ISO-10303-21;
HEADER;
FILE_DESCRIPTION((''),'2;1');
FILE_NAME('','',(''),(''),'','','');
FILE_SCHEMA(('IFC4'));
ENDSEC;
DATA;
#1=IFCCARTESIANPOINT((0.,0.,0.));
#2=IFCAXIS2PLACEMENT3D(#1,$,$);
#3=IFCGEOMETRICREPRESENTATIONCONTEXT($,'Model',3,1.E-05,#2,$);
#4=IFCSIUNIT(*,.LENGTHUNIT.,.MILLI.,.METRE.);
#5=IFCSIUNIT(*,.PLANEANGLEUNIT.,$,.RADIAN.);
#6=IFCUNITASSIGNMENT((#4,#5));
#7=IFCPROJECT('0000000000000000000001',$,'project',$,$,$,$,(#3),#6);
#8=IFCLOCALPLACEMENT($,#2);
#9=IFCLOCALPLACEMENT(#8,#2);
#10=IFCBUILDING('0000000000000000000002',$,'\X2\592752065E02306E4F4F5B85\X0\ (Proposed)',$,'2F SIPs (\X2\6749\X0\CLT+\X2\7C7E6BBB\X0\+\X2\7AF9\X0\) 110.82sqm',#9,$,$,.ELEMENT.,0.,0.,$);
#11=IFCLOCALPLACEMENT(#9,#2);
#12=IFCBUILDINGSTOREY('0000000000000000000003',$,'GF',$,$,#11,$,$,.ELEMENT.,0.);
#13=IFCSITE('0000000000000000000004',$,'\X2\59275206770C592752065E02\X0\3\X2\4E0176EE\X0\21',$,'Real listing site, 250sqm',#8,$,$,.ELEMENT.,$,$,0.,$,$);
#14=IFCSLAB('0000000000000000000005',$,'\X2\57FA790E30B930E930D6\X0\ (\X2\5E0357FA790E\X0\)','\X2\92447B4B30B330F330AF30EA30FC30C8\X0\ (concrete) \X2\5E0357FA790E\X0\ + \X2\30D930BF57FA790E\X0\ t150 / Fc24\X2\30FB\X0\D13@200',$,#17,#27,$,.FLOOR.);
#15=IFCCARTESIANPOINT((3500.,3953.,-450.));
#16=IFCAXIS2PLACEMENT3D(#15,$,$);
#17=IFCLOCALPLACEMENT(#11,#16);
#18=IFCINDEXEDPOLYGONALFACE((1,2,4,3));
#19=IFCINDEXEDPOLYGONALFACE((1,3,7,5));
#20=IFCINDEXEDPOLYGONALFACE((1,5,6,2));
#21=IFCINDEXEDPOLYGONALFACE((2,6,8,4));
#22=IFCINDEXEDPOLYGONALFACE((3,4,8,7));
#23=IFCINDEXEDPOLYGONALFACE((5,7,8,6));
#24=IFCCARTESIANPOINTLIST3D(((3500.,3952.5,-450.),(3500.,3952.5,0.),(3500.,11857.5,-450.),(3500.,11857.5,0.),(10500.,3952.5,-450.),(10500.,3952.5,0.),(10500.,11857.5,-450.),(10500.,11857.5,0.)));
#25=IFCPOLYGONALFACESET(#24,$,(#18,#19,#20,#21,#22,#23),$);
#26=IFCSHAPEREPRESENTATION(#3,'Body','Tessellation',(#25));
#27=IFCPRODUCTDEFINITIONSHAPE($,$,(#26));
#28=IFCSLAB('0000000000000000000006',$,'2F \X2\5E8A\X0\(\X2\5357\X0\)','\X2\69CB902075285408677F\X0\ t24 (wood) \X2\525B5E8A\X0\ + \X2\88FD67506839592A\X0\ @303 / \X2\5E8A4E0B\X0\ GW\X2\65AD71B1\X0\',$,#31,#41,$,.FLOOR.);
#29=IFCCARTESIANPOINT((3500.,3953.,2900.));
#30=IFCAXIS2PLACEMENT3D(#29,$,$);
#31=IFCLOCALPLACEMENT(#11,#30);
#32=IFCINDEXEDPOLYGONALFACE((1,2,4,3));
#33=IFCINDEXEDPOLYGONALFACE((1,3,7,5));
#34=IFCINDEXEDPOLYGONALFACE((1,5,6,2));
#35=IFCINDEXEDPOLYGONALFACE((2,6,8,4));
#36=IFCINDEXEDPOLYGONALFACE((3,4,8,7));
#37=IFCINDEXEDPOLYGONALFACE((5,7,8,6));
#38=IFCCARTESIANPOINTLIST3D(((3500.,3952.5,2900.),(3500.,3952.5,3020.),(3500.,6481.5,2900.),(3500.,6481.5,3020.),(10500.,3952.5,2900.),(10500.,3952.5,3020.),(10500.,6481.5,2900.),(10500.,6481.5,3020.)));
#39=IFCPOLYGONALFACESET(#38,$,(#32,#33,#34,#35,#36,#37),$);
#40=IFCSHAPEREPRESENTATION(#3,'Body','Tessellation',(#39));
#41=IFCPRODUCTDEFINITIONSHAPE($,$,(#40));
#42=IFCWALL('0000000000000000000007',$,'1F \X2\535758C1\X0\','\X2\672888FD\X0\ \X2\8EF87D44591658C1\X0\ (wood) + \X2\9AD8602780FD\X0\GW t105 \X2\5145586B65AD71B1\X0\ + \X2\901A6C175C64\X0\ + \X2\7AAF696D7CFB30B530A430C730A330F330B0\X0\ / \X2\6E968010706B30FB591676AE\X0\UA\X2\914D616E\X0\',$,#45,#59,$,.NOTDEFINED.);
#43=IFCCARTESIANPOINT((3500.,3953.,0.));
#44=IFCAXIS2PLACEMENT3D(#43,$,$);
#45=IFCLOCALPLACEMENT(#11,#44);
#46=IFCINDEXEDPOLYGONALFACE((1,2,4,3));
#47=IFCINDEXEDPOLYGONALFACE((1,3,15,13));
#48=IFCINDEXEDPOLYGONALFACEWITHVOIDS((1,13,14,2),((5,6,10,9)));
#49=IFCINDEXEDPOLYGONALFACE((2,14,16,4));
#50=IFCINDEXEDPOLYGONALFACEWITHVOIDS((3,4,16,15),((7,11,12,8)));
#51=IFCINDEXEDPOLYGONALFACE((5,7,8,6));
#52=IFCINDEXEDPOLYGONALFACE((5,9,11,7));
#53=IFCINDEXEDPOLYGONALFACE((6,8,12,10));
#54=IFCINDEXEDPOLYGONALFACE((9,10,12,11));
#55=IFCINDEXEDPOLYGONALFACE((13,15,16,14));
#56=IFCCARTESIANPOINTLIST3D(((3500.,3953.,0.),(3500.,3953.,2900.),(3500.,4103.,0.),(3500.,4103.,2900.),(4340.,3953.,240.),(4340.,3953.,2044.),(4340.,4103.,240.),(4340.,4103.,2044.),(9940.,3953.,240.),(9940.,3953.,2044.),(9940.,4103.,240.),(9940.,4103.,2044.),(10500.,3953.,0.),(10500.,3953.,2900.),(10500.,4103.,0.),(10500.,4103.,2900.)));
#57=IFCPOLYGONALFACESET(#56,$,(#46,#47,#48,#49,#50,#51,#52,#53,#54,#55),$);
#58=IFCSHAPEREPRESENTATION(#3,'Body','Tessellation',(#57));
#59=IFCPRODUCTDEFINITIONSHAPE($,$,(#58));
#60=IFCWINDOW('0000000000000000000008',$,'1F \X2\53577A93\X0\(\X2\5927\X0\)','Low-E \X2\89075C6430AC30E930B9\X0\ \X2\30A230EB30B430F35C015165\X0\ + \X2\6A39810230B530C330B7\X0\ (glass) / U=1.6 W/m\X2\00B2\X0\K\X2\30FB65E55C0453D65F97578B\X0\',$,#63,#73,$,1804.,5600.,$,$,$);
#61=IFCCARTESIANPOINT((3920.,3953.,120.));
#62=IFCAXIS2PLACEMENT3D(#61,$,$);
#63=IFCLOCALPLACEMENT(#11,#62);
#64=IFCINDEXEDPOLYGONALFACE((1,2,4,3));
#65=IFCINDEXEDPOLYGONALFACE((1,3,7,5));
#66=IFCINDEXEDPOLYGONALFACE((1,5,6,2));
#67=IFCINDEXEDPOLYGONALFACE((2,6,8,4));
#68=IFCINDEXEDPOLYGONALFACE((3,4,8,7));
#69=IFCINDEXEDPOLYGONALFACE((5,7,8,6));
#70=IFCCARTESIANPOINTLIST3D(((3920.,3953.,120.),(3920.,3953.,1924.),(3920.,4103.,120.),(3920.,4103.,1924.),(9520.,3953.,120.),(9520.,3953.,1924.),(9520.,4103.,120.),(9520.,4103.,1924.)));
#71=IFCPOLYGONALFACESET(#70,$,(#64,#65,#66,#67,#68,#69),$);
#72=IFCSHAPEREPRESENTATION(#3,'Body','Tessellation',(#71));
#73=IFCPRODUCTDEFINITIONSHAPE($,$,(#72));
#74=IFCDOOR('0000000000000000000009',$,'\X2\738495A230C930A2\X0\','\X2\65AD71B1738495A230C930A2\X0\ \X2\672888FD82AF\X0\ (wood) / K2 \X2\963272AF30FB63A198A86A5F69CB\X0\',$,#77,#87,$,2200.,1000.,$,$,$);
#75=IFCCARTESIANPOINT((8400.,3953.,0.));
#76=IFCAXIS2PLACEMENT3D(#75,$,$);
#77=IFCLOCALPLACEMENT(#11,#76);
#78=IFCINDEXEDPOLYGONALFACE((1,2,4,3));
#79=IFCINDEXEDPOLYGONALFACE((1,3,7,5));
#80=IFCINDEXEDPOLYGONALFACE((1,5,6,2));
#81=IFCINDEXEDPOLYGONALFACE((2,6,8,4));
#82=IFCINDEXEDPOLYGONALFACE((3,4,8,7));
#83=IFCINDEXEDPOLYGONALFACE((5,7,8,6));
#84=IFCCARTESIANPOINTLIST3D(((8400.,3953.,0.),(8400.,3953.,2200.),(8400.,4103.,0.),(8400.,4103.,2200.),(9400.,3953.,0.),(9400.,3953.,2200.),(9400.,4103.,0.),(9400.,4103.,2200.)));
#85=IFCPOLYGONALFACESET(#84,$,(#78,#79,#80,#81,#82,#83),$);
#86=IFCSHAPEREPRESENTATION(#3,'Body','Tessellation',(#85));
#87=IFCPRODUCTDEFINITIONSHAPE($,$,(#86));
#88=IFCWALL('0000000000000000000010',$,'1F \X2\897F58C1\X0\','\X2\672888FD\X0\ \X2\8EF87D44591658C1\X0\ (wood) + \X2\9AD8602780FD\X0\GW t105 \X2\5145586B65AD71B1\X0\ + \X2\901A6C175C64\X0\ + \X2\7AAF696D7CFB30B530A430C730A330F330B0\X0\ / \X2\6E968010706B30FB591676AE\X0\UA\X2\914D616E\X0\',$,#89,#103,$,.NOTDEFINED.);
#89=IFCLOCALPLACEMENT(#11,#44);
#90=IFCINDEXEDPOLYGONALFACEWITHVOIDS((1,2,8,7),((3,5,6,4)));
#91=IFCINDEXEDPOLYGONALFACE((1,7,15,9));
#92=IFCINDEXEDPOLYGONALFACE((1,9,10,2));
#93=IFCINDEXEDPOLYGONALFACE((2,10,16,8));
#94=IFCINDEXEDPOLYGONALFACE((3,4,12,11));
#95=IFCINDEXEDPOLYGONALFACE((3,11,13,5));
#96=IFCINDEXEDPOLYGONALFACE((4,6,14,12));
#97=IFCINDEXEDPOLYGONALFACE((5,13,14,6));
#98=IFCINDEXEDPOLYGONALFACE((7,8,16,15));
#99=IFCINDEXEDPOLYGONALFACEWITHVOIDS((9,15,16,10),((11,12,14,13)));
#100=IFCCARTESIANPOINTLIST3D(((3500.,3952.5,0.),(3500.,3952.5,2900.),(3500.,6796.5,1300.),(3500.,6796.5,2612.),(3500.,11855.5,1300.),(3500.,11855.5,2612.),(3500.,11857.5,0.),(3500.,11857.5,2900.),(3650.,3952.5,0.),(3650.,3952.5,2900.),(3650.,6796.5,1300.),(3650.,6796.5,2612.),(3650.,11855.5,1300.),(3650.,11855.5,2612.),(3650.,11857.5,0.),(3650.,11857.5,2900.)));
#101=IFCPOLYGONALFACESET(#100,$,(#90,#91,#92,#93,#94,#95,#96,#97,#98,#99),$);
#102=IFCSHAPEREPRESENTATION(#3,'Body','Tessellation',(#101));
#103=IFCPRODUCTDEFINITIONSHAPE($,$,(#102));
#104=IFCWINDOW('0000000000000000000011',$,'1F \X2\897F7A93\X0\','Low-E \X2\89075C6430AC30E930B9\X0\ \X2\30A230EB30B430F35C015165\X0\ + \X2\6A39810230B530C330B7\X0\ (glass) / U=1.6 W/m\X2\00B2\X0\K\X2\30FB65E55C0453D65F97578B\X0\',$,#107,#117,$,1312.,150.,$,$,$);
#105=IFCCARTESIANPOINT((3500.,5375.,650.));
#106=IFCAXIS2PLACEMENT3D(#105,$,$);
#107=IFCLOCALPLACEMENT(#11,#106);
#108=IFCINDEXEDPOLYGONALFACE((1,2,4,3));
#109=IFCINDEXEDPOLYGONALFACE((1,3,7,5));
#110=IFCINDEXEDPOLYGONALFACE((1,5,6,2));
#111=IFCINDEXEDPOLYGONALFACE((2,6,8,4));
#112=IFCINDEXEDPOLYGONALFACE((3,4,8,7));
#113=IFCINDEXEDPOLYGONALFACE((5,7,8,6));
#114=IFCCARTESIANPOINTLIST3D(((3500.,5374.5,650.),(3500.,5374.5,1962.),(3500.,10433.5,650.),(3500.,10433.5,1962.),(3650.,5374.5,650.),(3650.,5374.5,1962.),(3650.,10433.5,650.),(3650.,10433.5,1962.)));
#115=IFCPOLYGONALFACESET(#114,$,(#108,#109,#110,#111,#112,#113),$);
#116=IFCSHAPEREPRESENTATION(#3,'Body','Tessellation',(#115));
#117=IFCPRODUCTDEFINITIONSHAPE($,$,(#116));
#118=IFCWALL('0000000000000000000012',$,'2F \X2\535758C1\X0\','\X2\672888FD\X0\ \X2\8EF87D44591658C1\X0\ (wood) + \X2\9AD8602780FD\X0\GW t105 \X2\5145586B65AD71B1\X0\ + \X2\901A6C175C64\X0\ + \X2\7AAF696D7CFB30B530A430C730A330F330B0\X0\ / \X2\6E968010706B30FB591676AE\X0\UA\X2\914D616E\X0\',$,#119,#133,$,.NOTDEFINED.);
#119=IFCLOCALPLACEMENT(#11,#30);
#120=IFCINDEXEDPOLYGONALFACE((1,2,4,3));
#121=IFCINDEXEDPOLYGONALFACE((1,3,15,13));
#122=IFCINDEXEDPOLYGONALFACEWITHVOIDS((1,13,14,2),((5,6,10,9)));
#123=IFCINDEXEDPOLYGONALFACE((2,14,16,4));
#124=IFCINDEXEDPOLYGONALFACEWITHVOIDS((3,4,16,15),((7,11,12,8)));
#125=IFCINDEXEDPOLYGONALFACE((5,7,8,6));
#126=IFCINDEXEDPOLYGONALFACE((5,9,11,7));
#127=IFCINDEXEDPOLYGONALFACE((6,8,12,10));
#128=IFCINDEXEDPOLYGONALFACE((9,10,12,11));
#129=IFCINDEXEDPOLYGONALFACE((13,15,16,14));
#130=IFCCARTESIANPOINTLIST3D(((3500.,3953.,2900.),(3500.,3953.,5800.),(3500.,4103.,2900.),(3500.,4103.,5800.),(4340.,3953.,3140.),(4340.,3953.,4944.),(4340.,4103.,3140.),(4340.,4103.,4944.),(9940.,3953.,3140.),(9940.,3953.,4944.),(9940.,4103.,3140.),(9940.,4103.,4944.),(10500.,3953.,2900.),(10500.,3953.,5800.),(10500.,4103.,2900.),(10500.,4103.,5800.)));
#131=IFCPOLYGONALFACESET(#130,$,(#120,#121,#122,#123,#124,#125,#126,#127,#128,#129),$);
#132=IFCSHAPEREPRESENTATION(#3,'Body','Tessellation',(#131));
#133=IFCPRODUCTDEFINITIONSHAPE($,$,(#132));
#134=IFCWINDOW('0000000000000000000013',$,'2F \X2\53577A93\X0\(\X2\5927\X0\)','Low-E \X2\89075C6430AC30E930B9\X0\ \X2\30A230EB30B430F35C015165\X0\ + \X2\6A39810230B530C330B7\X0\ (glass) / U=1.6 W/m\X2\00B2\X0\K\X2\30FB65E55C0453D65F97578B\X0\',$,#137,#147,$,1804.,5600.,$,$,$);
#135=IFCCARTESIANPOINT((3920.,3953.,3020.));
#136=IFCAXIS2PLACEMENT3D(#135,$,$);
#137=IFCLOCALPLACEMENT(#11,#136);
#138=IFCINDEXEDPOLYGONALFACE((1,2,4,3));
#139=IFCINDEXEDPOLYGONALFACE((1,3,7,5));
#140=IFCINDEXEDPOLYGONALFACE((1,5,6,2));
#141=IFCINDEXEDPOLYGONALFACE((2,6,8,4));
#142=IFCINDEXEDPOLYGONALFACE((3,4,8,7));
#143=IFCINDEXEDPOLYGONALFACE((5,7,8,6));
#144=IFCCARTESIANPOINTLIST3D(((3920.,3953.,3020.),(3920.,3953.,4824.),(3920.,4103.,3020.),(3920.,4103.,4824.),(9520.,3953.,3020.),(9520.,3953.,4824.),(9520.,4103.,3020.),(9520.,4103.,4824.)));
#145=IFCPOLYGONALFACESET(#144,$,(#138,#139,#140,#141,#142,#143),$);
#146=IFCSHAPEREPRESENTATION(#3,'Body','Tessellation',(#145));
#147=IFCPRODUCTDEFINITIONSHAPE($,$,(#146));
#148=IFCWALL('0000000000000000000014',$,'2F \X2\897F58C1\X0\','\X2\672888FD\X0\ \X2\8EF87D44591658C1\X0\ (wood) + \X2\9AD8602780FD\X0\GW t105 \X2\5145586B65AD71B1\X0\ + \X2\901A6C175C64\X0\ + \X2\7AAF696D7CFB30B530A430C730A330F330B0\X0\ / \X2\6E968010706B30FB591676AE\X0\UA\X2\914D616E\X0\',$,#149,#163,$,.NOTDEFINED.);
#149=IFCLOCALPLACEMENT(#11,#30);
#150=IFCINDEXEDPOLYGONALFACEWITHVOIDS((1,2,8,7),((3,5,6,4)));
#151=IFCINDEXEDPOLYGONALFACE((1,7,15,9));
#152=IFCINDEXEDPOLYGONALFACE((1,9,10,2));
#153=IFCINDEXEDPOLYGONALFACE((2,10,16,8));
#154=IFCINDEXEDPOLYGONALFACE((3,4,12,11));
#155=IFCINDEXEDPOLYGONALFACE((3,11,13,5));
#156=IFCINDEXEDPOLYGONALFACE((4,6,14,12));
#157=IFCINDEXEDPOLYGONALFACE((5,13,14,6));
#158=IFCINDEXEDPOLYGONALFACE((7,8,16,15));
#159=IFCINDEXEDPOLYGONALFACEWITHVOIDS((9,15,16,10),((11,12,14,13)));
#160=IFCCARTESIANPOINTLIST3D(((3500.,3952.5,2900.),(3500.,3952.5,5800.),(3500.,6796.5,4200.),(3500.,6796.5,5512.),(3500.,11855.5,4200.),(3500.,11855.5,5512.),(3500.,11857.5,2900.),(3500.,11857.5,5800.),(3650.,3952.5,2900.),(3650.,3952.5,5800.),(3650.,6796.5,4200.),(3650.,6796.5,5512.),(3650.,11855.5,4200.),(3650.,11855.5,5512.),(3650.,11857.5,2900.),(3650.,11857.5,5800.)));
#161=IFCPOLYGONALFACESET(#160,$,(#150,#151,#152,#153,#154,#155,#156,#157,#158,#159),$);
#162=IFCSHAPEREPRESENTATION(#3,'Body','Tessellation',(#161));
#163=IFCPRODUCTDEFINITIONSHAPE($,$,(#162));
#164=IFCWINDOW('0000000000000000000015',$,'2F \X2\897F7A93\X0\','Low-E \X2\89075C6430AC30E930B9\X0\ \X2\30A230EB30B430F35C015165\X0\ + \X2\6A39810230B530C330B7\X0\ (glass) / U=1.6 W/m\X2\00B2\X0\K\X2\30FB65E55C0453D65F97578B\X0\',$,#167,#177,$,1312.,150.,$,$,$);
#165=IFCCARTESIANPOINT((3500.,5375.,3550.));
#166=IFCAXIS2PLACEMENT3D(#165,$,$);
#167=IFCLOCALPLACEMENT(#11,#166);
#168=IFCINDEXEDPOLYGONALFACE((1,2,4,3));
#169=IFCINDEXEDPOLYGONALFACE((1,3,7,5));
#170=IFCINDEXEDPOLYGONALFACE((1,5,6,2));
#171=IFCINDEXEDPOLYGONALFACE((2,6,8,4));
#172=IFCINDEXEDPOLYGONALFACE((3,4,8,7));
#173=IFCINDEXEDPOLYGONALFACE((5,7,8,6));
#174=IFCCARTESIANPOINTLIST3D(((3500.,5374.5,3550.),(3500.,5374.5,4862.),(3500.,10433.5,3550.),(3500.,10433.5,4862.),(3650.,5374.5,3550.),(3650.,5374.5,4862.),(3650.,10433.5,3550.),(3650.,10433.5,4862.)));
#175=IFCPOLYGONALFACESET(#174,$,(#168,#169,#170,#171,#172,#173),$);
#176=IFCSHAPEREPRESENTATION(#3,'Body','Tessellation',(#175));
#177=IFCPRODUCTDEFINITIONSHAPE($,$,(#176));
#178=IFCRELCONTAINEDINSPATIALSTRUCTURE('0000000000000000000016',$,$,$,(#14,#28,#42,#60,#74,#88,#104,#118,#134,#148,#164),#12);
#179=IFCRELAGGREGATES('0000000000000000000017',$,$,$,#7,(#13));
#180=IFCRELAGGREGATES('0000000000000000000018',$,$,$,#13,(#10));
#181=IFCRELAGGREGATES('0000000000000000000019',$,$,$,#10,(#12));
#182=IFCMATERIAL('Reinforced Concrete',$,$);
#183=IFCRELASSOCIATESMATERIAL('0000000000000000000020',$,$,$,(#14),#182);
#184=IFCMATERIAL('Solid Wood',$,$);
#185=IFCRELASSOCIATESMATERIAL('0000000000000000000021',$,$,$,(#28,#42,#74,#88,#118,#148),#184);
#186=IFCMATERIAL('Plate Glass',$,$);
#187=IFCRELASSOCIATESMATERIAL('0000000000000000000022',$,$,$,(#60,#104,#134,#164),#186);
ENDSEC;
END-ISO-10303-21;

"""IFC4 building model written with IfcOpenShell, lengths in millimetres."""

from ifc_helpers import new_model, si_unit, frame, frame_2d, origin, place, context, project, spatial, rectangle, extrude, material, element, fill, save


model = new_model("IFC4")

# Units and contexts
model_context = context("Model", 3, precision=1e-05, world=origin())
ifc_project = project(units=[si_unit("LENGTHUNIT", "METRE", prefix="MILLI"), si_unit("PLANEANGLEUNIT", "RADIAN")], contexts=[model_context])

# Site, building, storey
site_placement = place(None, origin())
site = spatial("IfcSite", under=ifc_project, at=site_placement, Name="大分県大分市3丁目21", ObjectType="Real listing site, 250sqm", CompositionType="ELEMENT", RefElevation=0.0)
building_placement = place(site_placement, origin())
building = spatial("IfcBuilding", under=site, at=building_placement, Name="大分市の住宅 (Proposed)", ObjectType="2F SIPs (杉CLT+籾殻+竹) 110.82sqm", CompositionType="ELEMENT", ElevationOfRefHeight=0.0, ElevationOfTerrain=0.0)
storey_placement = place(building_placement, origin())
storey = spatial("IfcBuildingStorey", under=building, at=storey_placement, Name="GF", CompositionType="ELEMENT", Elevation=0.0)

# Slabs
ifc_material_1 = material(Name="Reinforced Concrete")
slab_1_placement = place(storey_placement, frame((3500.0, 3953.0, -450.0)))
element("IfcSlab", 1, at=slab_1_placement, inside=storey, material=ifc_material_1, Name="基礎スラブ (布基礎)", Description="鉄筋コンクリート (concrete) 布基礎 + ベタ基礎 t150 / Fc24・D13@200", PredefinedType="FLOOR", context=model_context, shape_type="SweptSolid", body=[
    extrude(rectangle(XDim=7000.0, YDim=7905.0, at=frame_2d((3500.0, 3952.0))), frame((3500.0, 3953.0, -450.0)), (0.0, 0.0, 1.0), 450.0),
])
ifc_material_2 = material(Name="Solid Wood")
slab_2_placement = place(storey_placement, frame((3500.0, 3953.0, 2900.0)))
element("IfcSlab", 2, at=slab_2_placement, inside=storey, material=ifc_material_2, Name="2F 床(南)", Description="構造用合板 t24 (wood) 剛床 + 製材根太 @303 / 床下 GW断熱", PredefinedType="FLOOR", context=model_context, shape_type="SweptSolid", body=[
    extrude(rectangle(XDim=7000.0, YDim=2529.0, at=frame_2d((3500.0, 1264.0))), frame((3500.0, 3953.0, 2900.0)), (0.0, 0.0, 1.0), 120.0),
])

# Wall, openings, window, door
wall_1_placement = place(storey_placement, frame((3500.0, 3953.0, 0.0)))
wall_1 = element("IfcWall", 3, at=wall_1_placement, inside=storey, material=ifc_material_2, Name="1F 南壁", Description="木製 軸組外壁 (wood) + 高性能GW t105 充填断熱 + 通気層 + 窯業系サイディング / 準耐火・外皮UA配慮", PredefinedType="NOTDEFINED", context=model_context, shape_type="SweptSolid", body=[
    extrude(rectangle(XDim=7000.0, YDim=150.0, at=frame_2d((3500.0, 75.0))), frame((3500.0, 3953.0, 0.0)), (0.0, 0.0, 1.0), 2900.0),
])
opening_1_placement = place(storey_placement, frame((3920.0, 3953.0, 120.0)))
opening_1 = element("IfcOpeningElement", 4, at=opening_1_placement, cuts=wall_1, PredefinedType="NOTDEFINED", context=model_context, shape_type="SweptSolid", body=[
    extrude(rectangle(XDim=5600.0, YDim=150.0, at=frame_2d((2800.0, 75.0))), frame((3920.0, 3953.0, 120.0)), (0.0, 0.0, 1.0), 1804.0),
])
opening_2_placement = place(storey_placement, frame((8400.0, 3953.0, 0.0)))
opening_2 = element("IfcOpeningElement", 5, at=opening_2_placement, cuts=wall_1, PredefinedType="NOTDEFINED", context=model_context, shape_type="SweptSolid", body=[
    extrude(rectangle(XDim=1000.0, YDim=150.0, at=frame_2d((500.0, 75.0))), frame((8400.0, 3953.0, 0.0)), (0.0, 0.0, 1.0), 2200.0),
])
ifc_material_3 = material(Name="Plate Glass")
window_1_placement = place(storey_placement, frame((3920.0, 3953.0, 120.0)))
window_1 = element("IfcWindow", 6, at=window_1_placement, inside=storey, material=ifc_material_3, Name="1F 南窓(大)", Description="Low-E 複層ガラス アルゴン封入 + 樹脂サッシ (glass) / U=1.6 W/m²K・日射取得型", OverallHeight=1804.0, OverallWidth=5600.0, context=model_context, shape_type="SweptSolid", body=[
    extrude(rectangle(XDim=5600.0, YDim=150.0, at=frame_2d((2800.0, 75.0))), frame((3920.0, 3953.0, 120.0)), (0.0, 0.0, 1.0), 1804.0),
])
fill(opening_1, window_1)
door_placement = place(storey_placement, frame((8400.0, 3953.0, 0.0)))
door = element("IfcDoor", 7, at=door_placement, inside=storey, material=ifc_material_2, Name="玄関ドア", Description="断熱玄関ドア 木製芯 (wood) / K2 防犯・採風機構", OverallHeight=2200.0, OverallWidth=1000.0, context=model_context, shape_type="SweptSolid", body=[
    extrude(rectangle(XDim=1000.0, YDim=150.0, at=frame_2d((500.0, 75.0))), frame((8400.0, 3953.0, 0.0)), (0.0, 0.0, 1.0), 2200.0),
])
fill(opening_2, door)

# Walls, openings, windows
wall_2_placement = place(storey_placement, frame((3500.0, 3953.0, 0.0)))
wall_2 = element("IfcWall", 8, at=wall_2_placement, inside=storey, material=ifc_material_2, Name="1F 西壁", Description="木製 軸組外壁 (wood) + 高性能GW t105 充填断熱 + 通気層 + 窯業系サイディング / 準耐火・外皮UA配慮", PredefinedType="NOTDEFINED", context=model_context, shape_type="SweptSolid", body=[
    extrude(rectangle(XDim=150.0, YDim=7905.0, at=frame_2d((75.0, 3952.0))), frame((3500.0, 3953.0, 0.0)), (0.0, 0.0, 1.0), 2900.0),
])
opening_3_placement = place(storey_placement, frame((3500.0, 5375.0, 650.0)))
opening_3 = element("IfcOpeningElement", 9, at=opening_3_placement, cuts=wall_2, PredefinedType="NOTDEFINED", context=model_context, shape_type="SweptSolid", body=[
    extrude(rectangle(XDim=150.0, YDim=5059.0, at=frame_2d((75.0, 2529.0))), frame((3500.0, 5375.0, 650.0)), (0.0, 0.0, 1.0), 1312.0),
])
window_2_placement = place(storey_placement, frame((3500.0, 5375.0, 650.0)))
window_2 = element("IfcWindow", 10, at=window_2_placement, inside=storey, material=ifc_material_3, Name="1F 西窓", Description="Low-E 複層ガラス アルゴン封入 + 樹脂サッシ (glass) / U=1.6 W/m²K・日射取得型", OverallHeight=1312.0, OverallWidth=150.0, context=model_context, shape_type="SweptSolid", body=[
    extrude(rectangle(XDim=150.0, YDim=5059.0, at=frame_2d((75.0, 2529.0))), frame((3500.0, 5375.0, 650.0)), (0.0, 0.0, 1.0), 1312.0),
])
fill(opening_3, window_2)
wall_3_placement = place(storey_placement, frame((3500.0, 3953.0, 2900.0)))
wall_3 = element("IfcWall", 11, at=wall_3_placement, inside=storey, material=ifc_material_2, Name="2F 南壁", Description="木製 軸組外壁 (wood) + 高性能GW t105 充填断熱 + 通気層 + 窯業系サイディング / 準耐火・外皮UA配慮", PredefinedType="NOTDEFINED", context=model_context, shape_type="SweptSolid", body=[
    extrude(rectangle(XDim=7000.0, YDim=150.0, at=frame_2d((3500.0, 75.0))), frame((3500.0, 3953.0, 2900.0)), (0.0, 0.0, 1.0), 2900.0),
])
opening_4_placement = place(storey_placement, frame((3920.0, 3953.0, 3020.0)))
opening_4 = element("IfcOpeningElement", 12, at=opening_4_placement, cuts=wall_3, PredefinedType="NOTDEFINED", context=model_context, shape_type="SweptSolid", body=[
    extrude(rectangle(XDim=5600.0, YDim=150.0, at=frame_2d((2800.0, 75.0))), frame((3920.0, 3953.0, 3020.0)), (0.0, 0.0, 1.0), 1804.0),
])
window_3_placement = place(storey_placement, frame((3920.0, 3953.0, 3020.0)))
window_3 = element("IfcWindow", 13, at=window_3_placement, inside=storey, material=ifc_material_3, Name="2F 南窓(大)", Description="Low-E 複層ガラス アルゴン封入 + 樹脂サッシ (glass) / U=1.6 W/m²K・日射取得型", OverallHeight=1804.0, OverallWidth=5600.0, context=model_context, shape_type="SweptSolid", body=[
    extrude(rectangle(XDim=5600.0, YDim=150.0, at=frame_2d((2800.0, 75.0))), frame((3920.0, 3953.0, 3020.0)), (0.0, 0.0, 1.0), 1804.0),
])
fill(opening_4, window_3)
wall_4_placement = place(storey_placement, frame((3500.0, 3953.0, 2900.0)))
wall_4 = element("IfcWall", 14, at=wall_4_placement, inside=storey, material=ifc_material_2, Name="2F 西壁", Description="木製 軸組外壁 (wood) + 高性能GW t105 充填断熱 + 通気層 + 窯業系サイディング / 準耐火・外皮UA配慮", PredefinedType="NOTDEFINED", context=model_context, shape_type="SweptSolid", body=[
    extrude(rectangle(XDim=150.0, YDim=7905.0, at=frame_2d((75.0, 3952.0))), frame((3500.0, 3953.0, 2900.0)), (0.0, 0.0, 1.0), 2900.0),
])
opening_5_placement = place(storey_placement, frame((3500.0, 5375.0, 3550.0)))
opening_5 = element("IfcOpeningElement", 15, at=opening_5_placement, cuts=wall_4, PredefinedType="NOTDEFINED", context=model_context, shape_type="SweptSolid", body=[
    extrude(rectangle(XDim=150.0, YDim=5059.0, at=frame_2d((75.0, 2529.0))), frame((3500.0, 5375.0, 3550.0)), (0.0, 0.0, 1.0), 1312.0),
])
window_4_placement = place(storey_placement, frame((3500.0, 5375.0, 3550.0)))
window_4 = element("IfcWindow", 16, at=window_4_placement, inside=storey, material=ifc_material_3, Name="2F 西窓", Description="Low-E 複層ガラス アルゴン封入 + 樹脂サッシ (glass) / U=1.6 W/m²K・日射取得型", OverallHeight=1312.0, OverallWidth=150.0, context=model_context, shape_type="SweptSolid", body=[
    extrude(rectangle(XDim=150.0, YDim=5059.0, at=frame_2d((75.0, 2529.0))), frame((3500.0, 5375.0, 3550.0)), (0.0, 0.0, 1.0), 1312.0),
])
fill(opening_5, window_4)

save(model, "model.ifc")
